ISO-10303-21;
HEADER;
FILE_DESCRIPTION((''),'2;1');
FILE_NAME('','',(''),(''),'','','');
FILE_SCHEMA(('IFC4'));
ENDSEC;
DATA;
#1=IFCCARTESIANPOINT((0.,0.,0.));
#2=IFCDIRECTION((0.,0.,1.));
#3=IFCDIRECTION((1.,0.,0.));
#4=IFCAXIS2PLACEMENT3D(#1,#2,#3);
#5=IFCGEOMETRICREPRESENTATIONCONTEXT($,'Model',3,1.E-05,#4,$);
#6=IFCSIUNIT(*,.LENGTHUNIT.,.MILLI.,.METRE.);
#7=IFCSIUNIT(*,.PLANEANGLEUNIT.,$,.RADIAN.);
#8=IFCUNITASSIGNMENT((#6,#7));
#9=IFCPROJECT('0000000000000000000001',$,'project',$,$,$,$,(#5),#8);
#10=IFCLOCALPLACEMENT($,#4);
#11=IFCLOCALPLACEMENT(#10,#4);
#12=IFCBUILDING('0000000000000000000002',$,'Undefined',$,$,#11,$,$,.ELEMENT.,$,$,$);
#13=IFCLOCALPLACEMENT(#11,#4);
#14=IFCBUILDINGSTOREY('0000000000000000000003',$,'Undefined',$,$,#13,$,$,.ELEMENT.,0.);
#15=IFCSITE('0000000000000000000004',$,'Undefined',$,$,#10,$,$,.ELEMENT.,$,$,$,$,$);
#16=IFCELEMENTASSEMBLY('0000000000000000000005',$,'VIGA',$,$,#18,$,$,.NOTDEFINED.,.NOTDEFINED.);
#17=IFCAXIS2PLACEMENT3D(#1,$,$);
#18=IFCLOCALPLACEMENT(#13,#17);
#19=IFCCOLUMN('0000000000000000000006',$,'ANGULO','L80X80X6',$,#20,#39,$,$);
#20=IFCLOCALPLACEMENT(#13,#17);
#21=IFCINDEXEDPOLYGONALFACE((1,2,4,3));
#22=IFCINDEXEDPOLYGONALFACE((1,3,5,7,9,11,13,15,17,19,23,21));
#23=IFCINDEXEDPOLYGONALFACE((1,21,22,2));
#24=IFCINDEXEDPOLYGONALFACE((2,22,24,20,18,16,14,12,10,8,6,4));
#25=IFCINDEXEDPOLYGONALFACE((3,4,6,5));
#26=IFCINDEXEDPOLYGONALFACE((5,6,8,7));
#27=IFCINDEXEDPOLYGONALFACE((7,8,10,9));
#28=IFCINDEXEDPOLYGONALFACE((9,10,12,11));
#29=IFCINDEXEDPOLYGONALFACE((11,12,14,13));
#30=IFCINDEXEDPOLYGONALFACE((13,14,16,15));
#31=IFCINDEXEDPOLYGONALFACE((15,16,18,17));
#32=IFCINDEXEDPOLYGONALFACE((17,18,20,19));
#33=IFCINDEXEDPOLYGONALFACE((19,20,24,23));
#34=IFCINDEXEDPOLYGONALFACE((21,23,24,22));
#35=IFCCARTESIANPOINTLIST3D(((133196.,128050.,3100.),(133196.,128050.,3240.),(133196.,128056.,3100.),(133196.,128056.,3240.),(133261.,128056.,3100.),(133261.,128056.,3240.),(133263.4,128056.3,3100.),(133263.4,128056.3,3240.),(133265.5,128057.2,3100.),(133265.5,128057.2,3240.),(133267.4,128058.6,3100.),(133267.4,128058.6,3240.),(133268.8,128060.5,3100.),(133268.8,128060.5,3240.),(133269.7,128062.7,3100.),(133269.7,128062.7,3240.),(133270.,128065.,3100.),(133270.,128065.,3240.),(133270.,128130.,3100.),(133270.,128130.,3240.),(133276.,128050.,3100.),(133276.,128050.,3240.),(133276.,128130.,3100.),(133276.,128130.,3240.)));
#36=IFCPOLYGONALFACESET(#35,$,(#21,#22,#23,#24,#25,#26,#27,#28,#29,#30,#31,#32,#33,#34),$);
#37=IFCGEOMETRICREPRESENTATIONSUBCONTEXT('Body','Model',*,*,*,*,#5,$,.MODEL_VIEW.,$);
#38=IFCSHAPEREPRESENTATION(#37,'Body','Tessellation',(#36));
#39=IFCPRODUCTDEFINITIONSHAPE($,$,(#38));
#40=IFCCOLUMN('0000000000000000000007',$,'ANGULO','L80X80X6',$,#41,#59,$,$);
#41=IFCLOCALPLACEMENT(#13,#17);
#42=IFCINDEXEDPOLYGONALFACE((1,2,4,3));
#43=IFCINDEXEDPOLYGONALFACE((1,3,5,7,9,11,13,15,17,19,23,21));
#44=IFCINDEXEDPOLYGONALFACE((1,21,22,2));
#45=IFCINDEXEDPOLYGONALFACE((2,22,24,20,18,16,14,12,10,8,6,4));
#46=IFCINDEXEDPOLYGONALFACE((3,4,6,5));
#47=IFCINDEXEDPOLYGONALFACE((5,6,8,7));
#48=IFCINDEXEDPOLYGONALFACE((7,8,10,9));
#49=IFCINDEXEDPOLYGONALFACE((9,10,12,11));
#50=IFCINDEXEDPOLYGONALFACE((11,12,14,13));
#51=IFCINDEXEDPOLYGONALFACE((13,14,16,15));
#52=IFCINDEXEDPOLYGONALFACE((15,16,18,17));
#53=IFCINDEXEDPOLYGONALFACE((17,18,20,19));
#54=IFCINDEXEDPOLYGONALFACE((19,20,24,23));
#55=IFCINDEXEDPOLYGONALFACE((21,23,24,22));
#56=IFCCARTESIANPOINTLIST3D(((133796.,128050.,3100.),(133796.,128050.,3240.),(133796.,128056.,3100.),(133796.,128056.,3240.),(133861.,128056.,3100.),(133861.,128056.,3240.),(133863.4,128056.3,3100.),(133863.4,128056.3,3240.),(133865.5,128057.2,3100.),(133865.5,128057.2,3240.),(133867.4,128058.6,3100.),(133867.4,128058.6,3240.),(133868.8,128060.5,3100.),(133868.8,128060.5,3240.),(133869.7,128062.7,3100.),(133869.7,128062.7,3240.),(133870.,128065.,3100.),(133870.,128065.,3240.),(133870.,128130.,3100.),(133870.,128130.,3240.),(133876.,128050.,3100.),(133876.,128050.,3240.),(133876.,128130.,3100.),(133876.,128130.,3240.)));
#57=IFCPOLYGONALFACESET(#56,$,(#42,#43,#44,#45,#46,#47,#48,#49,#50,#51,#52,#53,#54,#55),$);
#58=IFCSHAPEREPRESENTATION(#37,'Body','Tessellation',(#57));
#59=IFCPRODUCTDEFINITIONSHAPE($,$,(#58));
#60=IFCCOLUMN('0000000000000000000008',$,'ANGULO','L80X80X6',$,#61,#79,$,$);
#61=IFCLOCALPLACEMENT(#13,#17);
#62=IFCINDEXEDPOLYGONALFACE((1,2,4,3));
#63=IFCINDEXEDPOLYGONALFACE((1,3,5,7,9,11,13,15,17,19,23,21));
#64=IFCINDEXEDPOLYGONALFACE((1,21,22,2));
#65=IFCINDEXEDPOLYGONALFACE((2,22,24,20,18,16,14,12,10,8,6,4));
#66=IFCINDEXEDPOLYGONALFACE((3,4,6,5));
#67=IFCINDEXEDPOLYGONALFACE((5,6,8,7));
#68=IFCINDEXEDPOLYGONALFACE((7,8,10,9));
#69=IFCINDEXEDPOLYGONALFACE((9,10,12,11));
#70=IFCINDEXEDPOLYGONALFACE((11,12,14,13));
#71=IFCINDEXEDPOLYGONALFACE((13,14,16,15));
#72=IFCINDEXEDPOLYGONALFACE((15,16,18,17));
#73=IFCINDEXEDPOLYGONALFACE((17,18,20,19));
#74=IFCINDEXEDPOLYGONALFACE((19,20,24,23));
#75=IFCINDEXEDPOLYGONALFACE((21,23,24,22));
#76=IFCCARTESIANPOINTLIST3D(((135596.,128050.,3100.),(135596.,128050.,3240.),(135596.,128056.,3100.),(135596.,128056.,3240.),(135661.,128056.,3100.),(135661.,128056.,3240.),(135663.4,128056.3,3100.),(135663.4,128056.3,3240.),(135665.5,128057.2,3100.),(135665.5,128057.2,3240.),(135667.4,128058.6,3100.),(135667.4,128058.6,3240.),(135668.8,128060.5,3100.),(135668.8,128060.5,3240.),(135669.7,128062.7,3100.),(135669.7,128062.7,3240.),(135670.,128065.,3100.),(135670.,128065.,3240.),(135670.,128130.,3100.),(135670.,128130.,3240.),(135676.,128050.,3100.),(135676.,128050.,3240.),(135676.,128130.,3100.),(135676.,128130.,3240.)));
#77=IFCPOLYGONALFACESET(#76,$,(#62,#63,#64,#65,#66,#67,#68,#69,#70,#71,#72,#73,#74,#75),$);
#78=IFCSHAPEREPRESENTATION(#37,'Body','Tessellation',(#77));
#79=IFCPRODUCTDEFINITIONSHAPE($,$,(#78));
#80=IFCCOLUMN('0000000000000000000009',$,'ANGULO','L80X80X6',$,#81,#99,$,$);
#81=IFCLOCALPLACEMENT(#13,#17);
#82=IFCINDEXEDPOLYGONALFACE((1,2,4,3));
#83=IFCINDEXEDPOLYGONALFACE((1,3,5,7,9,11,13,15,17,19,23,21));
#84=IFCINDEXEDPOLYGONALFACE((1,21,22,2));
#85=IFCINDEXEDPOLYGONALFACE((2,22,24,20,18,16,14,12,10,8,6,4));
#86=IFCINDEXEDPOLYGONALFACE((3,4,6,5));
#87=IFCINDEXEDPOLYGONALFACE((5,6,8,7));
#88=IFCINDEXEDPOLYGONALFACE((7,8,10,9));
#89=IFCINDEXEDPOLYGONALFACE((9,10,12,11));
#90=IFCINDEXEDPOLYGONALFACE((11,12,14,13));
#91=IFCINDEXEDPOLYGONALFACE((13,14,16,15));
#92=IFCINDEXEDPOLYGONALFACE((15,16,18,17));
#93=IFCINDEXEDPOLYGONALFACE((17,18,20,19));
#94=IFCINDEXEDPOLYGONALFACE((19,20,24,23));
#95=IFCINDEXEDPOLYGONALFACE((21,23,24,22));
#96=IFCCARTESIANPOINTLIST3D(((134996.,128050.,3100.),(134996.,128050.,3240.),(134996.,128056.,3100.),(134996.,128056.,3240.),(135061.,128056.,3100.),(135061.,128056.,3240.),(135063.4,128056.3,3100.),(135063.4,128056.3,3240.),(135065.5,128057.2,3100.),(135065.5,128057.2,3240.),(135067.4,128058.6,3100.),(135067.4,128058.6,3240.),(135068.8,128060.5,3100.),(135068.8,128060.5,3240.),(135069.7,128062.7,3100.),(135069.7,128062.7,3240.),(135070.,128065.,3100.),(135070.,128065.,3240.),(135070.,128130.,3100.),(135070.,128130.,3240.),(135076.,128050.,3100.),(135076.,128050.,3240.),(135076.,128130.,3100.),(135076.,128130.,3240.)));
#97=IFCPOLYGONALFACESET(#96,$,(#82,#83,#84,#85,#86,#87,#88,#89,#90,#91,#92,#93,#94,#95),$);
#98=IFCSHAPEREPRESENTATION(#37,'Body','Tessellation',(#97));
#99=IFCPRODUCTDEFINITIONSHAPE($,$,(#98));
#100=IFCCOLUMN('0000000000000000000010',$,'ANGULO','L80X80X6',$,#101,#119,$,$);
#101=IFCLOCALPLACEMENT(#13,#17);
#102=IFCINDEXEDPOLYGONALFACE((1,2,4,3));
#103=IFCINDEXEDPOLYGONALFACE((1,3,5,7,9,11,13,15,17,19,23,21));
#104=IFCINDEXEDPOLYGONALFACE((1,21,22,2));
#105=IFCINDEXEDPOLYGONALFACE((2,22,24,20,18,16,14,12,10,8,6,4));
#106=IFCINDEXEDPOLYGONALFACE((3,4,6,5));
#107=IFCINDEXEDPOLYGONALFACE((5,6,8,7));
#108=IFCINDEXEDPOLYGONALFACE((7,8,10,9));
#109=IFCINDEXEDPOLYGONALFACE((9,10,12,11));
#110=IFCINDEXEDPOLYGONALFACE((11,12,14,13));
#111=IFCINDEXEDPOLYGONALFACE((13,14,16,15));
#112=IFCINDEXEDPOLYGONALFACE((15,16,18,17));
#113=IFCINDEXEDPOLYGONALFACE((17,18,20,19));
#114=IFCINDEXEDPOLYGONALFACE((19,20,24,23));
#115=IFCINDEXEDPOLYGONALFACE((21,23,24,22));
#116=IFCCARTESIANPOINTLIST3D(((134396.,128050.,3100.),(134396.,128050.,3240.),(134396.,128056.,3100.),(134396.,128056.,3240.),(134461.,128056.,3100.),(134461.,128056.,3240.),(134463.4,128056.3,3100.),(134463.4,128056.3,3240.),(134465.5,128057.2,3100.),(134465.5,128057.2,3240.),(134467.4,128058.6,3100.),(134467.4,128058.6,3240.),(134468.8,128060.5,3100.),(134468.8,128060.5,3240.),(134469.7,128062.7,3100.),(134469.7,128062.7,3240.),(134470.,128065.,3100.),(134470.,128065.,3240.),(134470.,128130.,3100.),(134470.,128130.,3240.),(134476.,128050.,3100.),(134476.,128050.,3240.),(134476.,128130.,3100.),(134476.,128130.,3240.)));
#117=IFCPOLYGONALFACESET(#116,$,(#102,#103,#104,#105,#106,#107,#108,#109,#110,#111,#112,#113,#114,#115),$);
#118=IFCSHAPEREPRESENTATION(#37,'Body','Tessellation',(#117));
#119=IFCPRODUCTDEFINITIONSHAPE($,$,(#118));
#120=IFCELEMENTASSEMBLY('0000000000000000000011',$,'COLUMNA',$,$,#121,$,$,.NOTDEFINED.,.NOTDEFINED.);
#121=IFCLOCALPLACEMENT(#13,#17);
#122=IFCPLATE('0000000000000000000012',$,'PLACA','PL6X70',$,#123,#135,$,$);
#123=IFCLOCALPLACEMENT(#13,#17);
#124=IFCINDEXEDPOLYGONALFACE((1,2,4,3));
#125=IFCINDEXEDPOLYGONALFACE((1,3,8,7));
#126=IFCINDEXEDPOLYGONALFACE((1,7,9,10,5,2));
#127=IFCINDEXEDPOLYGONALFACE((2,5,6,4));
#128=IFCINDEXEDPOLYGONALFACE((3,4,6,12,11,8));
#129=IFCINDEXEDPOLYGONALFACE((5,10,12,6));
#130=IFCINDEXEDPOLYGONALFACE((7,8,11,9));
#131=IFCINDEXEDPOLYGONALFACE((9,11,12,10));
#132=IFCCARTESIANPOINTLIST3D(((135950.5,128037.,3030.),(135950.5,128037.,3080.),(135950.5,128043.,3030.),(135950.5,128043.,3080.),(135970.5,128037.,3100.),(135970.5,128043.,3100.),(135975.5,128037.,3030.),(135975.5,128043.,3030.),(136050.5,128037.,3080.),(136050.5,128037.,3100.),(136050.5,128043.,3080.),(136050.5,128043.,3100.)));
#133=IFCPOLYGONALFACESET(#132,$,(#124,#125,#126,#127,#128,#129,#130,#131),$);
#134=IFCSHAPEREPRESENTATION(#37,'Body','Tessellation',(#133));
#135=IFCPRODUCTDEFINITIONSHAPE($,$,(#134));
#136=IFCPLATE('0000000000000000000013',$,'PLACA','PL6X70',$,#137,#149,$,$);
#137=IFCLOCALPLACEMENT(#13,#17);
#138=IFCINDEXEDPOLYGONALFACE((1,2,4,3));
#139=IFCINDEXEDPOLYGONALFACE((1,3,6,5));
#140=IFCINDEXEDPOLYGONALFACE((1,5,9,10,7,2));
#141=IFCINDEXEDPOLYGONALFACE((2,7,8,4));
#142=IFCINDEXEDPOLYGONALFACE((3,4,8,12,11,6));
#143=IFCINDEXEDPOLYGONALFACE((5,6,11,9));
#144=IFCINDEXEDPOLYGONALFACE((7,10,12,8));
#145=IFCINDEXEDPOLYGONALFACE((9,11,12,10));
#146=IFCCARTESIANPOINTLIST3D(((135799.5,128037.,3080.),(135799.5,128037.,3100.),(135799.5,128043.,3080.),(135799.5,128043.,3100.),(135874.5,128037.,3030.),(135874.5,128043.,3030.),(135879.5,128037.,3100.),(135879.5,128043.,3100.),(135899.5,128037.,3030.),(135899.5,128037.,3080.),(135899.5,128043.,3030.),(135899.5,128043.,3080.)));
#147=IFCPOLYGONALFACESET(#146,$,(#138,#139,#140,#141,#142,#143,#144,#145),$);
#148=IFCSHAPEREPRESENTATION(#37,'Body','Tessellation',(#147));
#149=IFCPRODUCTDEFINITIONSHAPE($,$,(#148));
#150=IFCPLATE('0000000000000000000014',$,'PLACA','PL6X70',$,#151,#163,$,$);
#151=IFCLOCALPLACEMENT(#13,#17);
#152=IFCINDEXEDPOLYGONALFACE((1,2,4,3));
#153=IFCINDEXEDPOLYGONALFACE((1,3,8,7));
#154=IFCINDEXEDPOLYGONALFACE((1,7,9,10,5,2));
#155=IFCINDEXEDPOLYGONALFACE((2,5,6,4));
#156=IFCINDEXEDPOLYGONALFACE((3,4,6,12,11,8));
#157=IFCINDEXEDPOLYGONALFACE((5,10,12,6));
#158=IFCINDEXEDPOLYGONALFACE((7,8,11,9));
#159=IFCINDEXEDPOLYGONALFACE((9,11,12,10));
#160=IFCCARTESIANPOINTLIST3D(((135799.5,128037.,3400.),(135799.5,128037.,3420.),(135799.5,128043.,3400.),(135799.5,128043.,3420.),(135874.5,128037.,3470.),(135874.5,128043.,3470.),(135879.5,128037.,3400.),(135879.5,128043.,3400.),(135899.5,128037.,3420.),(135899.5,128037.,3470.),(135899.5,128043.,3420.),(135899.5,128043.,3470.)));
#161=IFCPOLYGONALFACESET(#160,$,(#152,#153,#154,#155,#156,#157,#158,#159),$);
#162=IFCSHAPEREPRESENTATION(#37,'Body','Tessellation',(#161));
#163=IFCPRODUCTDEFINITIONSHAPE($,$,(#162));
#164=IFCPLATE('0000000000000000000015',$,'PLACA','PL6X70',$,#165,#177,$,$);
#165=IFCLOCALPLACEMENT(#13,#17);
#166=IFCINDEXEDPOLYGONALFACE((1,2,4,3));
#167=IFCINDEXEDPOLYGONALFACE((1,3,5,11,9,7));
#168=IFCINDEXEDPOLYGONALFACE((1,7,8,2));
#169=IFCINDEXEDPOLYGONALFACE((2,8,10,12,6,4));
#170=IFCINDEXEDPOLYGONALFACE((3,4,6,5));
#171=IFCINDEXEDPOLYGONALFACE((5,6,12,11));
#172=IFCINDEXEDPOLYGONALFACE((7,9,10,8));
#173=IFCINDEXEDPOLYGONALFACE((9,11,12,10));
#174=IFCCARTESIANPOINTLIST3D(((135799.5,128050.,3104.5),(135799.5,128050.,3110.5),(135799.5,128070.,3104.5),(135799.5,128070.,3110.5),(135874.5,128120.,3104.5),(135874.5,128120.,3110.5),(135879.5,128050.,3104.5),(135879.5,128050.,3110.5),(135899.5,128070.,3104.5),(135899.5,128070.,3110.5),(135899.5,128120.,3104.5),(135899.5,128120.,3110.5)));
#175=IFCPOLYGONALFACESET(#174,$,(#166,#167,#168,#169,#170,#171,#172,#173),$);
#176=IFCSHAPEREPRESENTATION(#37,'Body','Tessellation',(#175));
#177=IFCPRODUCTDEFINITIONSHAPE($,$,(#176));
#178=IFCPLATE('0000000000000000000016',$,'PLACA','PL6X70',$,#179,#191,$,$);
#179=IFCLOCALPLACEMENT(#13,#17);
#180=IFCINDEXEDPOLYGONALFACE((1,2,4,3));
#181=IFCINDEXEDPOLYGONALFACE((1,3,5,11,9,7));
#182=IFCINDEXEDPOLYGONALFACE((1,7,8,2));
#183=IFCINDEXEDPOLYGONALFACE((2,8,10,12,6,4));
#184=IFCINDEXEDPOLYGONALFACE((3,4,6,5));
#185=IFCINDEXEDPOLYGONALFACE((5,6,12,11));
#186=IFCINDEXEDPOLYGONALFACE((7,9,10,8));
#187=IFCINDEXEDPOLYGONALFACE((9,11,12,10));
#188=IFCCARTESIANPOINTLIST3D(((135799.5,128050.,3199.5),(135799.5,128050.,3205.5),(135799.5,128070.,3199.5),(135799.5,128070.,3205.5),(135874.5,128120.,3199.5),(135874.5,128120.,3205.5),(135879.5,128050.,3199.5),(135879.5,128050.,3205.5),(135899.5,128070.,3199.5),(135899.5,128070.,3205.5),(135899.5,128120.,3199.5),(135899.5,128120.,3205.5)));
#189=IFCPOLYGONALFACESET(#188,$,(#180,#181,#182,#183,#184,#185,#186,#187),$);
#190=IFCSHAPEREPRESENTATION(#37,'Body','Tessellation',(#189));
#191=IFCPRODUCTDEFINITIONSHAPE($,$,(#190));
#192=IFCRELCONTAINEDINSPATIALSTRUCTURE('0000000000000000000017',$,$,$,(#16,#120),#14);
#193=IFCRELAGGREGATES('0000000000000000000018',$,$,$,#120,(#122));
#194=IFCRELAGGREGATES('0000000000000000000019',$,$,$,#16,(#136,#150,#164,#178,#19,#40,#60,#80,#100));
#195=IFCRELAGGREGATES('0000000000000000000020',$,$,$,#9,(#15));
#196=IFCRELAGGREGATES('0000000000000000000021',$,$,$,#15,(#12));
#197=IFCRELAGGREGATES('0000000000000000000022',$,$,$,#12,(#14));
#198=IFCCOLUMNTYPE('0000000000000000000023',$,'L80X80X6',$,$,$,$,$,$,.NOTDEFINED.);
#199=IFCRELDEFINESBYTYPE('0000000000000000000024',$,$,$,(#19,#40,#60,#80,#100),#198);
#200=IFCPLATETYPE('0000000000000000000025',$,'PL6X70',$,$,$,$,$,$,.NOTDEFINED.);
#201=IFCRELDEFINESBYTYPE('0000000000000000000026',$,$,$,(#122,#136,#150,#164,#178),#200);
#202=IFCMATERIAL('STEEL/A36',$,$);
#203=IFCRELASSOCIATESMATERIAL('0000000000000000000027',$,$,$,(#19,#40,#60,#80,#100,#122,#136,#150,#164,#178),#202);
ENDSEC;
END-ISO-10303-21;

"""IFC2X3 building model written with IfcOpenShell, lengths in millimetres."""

from ifc_helpers import new_model, si_unit, frame, origin_with_axes, origin_2d_with_axis, place, context, subcontext, project, spatial, polyline, l_section, outline, extrude, material, type_object, element, aggregate, save


model = new_model("IFC2X3")

# Units and contexts
model_context = context("Model", 3, precision=1e-05, world=origin_with_axes())
body_context = subcontext(model_context, "Body", "Model", "MODEL_VIEW")
ifc_project = project(units=[si_unit("LENGTHUNIT", "METRE", prefix="MILLI"), si_unit("PLANEANGLEUNIT", "RADIAN")], contexts=[model_context])

# Site, building, storey
site_placement = place(None, origin_with_axes())
site = spatial("IfcSite", under=ifc_project, at=site_placement, Name="Undefined", CompositionType="ELEMENT")
building_placement = place(site_placement, origin_with_axes())
building = spatial("IfcBuilding", under=site, at=building_placement, Name="Undefined", CompositionType="ELEMENT")
storey_placement = place(building_placement, origin_with_axes())
storey = spatial("IfcBuildingStorey", under=building, at=storey_placement, Name="Undefined", CompositionType="ELEMENT", Elevation=0.0)

# Element assembly, columns
assembly_1_placement = place(storey_placement, origin_with_axes())
assembly_1 = element("IfcElementAssembly", 1, at=assembly_1_placement, inside=storey, Name="VIGA", AssemblyPlace="NOTDEFINED", PredefinedType="NOTDEFINED")
ifc_material_1 = material(Name="STEEL/A36")
column_type = type_object("IfcColumnType", Name="L80X80X6", PredefinedType="NOTDEFINED")
column_1_placement = place(assembly_1_placement, frame((133236.0, 128090.0, 3100.0), z_axis=(0.0, 0.0, 1.0), x_axis=(0.0, 1.0, 0.0)))
column_1 = element("IfcColumn", 2, at=column_1_placement, type_object=column_type, material=ifc_material_1, Name="ANGULO", Description="L80X80X6", context=body_context, shape_type="SweptSolid", body=[
    extrude(l_section(Depth=80.0, Width=80.0, Thickness=6.0, FilletRadius=9.0, at=origin_2d_with_axis()), frame((0.0, 0.0, 140.0), z_axis=(0.0, 0.0, -1.0), x_axis=(0.0, 1.0, 0.0)), (0.0, 0.0, 1.0), 140.0),
])
column_2_placement = place(assembly_1_placement, frame((133836.0, 128090.0, 3100.0), z_axis=(0.0, 0.0, 1.0), x_axis=(0.0, 1.0, 0.0)))
column_2 = element("IfcColumn", 3, at=column_2_placement, type_object=column_type, material=ifc_material_1, Name="ANGULO", Description="L80X80X6", context=body_context, shape_type="SweptSolid", body=[
    extrude(l_section(Depth=80.0, Width=80.0, Thickness=6.0, FilletRadius=9.0, at=origin_2d_with_axis()), frame((0.0, 0.0, 140.0), z_axis=(0.0, 0.0, -1.0), x_axis=(0.0, 1.0, 0.0)), (0.0, 0.0, 1.0), 140.0),
])
column_3_placement = place(assembly_1_placement, frame((135636.0, 128090.0, 3100.0), z_axis=(0.0, 0.0, 1.0), x_axis=(0.0, 1.0, 0.0)))
column_3 = element("IfcColumn", 4, at=column_3_placement, type_object=column_type, material=ifc_material_1, Name="ANGULO", Description="L80X80X6", context=body_context, shape_type="SweptSolid", body=[
    extrude(l_section(Depth=80.0, Width=80.0, Thickness=6.0, FilletRadius=9.0, at=origin_2d_with_axis()), frame((0.0, 0.0, 140.0), z_axis=(0.0, 0.0, -1.0), x_axis=(0.0, 1.0, 0.0)), (0.0, 0.0, 1.0), 140.0),
])
column_4_placement = place(assembly_1_placement, frame((135036.0, 128090.0, 3100.0), z_axis=(0.0, 0.0, 1.0), x_axis=(0.0, 1.0, 0.0)))
column_4 = element("IfcColumn", 5, at=column_4_placement, type_object=column_type, material=ifc_material_1, Name="ANGULO", Description="L80X80X6", context=body_context, shape_type="SweptSolid", body=[
    extrude(l_section(Depth=80.0, Width=80.0, Thickness=6.0, FilletRadius=9.0, at=origin_2d_with_axis()), frame((0.0, 0.0, 140.0), z_axis=(0.0, 0.0, -1.0), x_axis=(0.0, 1.0, 0.0)), (0.0, 0.0, 1.0), 140.0),
])
column_5_placement = place(assembly_1_placement, frame((134436.0, 128090.0, 3100.0), z_axis=(0.0, 0.0, 1.0), x_axis=(0.0, 1.0, 0.0)))
column_5 = element("IfcColumn", 6, at=column_5_placement, type_object=column_type, material=ifc_material_1, Name="ANGULO", Description="L80X80X6", context=body_context, shape_type="SweptSolid", body=[
    extrude(l_section(Depth=80.0, Width=80.0, Thickness=6.0, FilletRadius=9.0, at=origin_2d_with_axis()), frame((0.0, 0.0, 140.0), z_axis=(0.0, 0.0, -1.0), x_axis=(0.0, 1.0, 0.0)), (0.0, 0.0, 1.0), 140.0),
])

# Element assembly
assembly_2_placement = place(storey_placement, origin_with_axes())
assembly_2 = element("IfcElementAssembly", 7, at=assembly_2_placement, inside=storey, Name="COLUMNA", AssemblyPlace="NOTDEFINED", PredefinedType="NOTDEFINED")

# Plates
plate_type_1 = type_object("IfcPlateType", Name="PL6X70", PredefinedType="NOTDEFINED")
plate_1_placement = place(assembly_2_placement, frame((135950.5, 128040.0, 3030.0), z_axis=(0.0, -1.0, 0.0), x_axis=(1.0, 0.0, 0.0)))
plate_1 = element("IfcPlate", 8, at=plate_1_placement, type_object=plate_type_1, material=ifc_material_1, Name="PLACA", Description="PL6X70", context=body_context, shape_type="SweptSolid", body=[
    extrude(outline(polyline([(0.0, 0.0), (25.0, 0.0), (100.0, 50.0), (100.0, 70.0), (20.0, 70.0), (0.0, 50.0), (0.0, 0.0)])), frame((0.0, 0.0, -3.0), z_axis=(0.0, 0.0, 1.0), x_axis=(1.0, 0.0, 0.0)), (0.0, 0.0, 1.0), 6.0),
])
plate_2_placement = place(assembly_1_placement, frame((135899.5, 128040.0, 3030.0), z_axis=(0.0, 1.0, 0.0), x_axis=(-1.0, 0.0, 0.0)))
plate_2 = element("IfcPlate", 9, at=plate_2_placement, type_object=plate_type_1, material=ifc_material_1, Name="PLACA", Description="PL6X70", context=body_context, shape_type="SweptSolid", body=[
    extrude(outline(polyline([(0.0, 0.0), (25.0, 0.0), (100.0, 50.0), (100.0, 70.0), (20.0, 70.0), (0.0, 50.0), (0.0, 0.0)])), frame((0.0, 0.0, -3.0), z_axis=(0.0, 0.0, 1.0), x_axis=(1.0, 0.0, 0.0)), (0.0, 0.0, 1.0), 6.0),
])
plate_3_placement = place(assembly_1_placement, frame((135899.5, 128040.0, 3470.0), z_axis=(0.0, -1.0, 0.0), x_axis=(-1.0, 0.0, 0.0)))
plate_3 = element("IfcPlate", 10, at=plate_3_placement, type_object=plate_type_1, material=ifc_material_1, Name="PLACA", Description="PL6X70", context=body_context, shape_type="SweptSolid", body=[
    extrude(outline(polyline([(0.0, 0.0), (25.0, 0.0), (100.0, 50.0), (100.0, 70.0), (20.0, 70.0), (0.0, 50.0), (0.0, 0.0)])), frame((0.0, 0.0, -3.0), z_axis=(0.0, 0.0, 1.0), x_axis=(1.0, 0.0, 0.0)), (0.0, 0.0, 1.0), 6.0),
])
plate_4_placement = place(assembly_1_placement, frame((135899.5, 128120.0, 3107.5), z_axis=(0.0, 0.0, 1.0), x_axis=(-1.0, 0.0, 0.0)))
plate_4 = element("IfcPlate", 11, at=plate_4_placement, type_object=plate_type_1, material=ifc_material_1, Name="PLACA", Description="PL6X70", context=body_context, shape_type="SweptSolid", body=[
    extrude(outline(polyline([(0.0, 0.0), (25.0, 0.0), (100.0, 50.0), (100.0, 70.0), (20.0, 70.0), (0.0, 50.0), (0.0, 0.0)])), frame((0.0, 0.0, -3.0), z_axis=(0.0, 0.0, 1.0), x_axis=(1.0, 0.0, 0.0)), (0.0, 0.0, 1.0), 6.0),
])
plate_5_placement = place(assembly_1_placement, frame((135899.5, 128120.0, 3202.5), z_axis=(0.0, 0.0, 1.0), x_axis=(-1.0, 0.0, 0.0)))
plate_5 = element("IfcPlate", 12, at=plate_5_placement, type_object=plate_type_1, material=ifc_material_1, Name="PLACA", Description="PL6X70", context=body_context, shape_type="SweptSolid", body=[
    extrude(outline(polyline([(0.0, 0.0), (25.0, 0.0), (100.0, 50.0), (100.0, 70.0), (20.0, 70.0), (0.0, 50.0), (0.0, 0.0)])), frame((0.0, 0.0, -3.0), z_axis=(0.0, 0.0, 1.0), x_axis=(1.0, 0.0, 0.0)), (0.0, 0.0, 1.0), 6.0),
])

aggregate(assembly_2, [plate_1])
aggregate(assembly_1, [plate_2, plate_3, plate_4, plate_5, column_1, column_2, column_3, column_4, column_5])

save(model, "model.ifc")
